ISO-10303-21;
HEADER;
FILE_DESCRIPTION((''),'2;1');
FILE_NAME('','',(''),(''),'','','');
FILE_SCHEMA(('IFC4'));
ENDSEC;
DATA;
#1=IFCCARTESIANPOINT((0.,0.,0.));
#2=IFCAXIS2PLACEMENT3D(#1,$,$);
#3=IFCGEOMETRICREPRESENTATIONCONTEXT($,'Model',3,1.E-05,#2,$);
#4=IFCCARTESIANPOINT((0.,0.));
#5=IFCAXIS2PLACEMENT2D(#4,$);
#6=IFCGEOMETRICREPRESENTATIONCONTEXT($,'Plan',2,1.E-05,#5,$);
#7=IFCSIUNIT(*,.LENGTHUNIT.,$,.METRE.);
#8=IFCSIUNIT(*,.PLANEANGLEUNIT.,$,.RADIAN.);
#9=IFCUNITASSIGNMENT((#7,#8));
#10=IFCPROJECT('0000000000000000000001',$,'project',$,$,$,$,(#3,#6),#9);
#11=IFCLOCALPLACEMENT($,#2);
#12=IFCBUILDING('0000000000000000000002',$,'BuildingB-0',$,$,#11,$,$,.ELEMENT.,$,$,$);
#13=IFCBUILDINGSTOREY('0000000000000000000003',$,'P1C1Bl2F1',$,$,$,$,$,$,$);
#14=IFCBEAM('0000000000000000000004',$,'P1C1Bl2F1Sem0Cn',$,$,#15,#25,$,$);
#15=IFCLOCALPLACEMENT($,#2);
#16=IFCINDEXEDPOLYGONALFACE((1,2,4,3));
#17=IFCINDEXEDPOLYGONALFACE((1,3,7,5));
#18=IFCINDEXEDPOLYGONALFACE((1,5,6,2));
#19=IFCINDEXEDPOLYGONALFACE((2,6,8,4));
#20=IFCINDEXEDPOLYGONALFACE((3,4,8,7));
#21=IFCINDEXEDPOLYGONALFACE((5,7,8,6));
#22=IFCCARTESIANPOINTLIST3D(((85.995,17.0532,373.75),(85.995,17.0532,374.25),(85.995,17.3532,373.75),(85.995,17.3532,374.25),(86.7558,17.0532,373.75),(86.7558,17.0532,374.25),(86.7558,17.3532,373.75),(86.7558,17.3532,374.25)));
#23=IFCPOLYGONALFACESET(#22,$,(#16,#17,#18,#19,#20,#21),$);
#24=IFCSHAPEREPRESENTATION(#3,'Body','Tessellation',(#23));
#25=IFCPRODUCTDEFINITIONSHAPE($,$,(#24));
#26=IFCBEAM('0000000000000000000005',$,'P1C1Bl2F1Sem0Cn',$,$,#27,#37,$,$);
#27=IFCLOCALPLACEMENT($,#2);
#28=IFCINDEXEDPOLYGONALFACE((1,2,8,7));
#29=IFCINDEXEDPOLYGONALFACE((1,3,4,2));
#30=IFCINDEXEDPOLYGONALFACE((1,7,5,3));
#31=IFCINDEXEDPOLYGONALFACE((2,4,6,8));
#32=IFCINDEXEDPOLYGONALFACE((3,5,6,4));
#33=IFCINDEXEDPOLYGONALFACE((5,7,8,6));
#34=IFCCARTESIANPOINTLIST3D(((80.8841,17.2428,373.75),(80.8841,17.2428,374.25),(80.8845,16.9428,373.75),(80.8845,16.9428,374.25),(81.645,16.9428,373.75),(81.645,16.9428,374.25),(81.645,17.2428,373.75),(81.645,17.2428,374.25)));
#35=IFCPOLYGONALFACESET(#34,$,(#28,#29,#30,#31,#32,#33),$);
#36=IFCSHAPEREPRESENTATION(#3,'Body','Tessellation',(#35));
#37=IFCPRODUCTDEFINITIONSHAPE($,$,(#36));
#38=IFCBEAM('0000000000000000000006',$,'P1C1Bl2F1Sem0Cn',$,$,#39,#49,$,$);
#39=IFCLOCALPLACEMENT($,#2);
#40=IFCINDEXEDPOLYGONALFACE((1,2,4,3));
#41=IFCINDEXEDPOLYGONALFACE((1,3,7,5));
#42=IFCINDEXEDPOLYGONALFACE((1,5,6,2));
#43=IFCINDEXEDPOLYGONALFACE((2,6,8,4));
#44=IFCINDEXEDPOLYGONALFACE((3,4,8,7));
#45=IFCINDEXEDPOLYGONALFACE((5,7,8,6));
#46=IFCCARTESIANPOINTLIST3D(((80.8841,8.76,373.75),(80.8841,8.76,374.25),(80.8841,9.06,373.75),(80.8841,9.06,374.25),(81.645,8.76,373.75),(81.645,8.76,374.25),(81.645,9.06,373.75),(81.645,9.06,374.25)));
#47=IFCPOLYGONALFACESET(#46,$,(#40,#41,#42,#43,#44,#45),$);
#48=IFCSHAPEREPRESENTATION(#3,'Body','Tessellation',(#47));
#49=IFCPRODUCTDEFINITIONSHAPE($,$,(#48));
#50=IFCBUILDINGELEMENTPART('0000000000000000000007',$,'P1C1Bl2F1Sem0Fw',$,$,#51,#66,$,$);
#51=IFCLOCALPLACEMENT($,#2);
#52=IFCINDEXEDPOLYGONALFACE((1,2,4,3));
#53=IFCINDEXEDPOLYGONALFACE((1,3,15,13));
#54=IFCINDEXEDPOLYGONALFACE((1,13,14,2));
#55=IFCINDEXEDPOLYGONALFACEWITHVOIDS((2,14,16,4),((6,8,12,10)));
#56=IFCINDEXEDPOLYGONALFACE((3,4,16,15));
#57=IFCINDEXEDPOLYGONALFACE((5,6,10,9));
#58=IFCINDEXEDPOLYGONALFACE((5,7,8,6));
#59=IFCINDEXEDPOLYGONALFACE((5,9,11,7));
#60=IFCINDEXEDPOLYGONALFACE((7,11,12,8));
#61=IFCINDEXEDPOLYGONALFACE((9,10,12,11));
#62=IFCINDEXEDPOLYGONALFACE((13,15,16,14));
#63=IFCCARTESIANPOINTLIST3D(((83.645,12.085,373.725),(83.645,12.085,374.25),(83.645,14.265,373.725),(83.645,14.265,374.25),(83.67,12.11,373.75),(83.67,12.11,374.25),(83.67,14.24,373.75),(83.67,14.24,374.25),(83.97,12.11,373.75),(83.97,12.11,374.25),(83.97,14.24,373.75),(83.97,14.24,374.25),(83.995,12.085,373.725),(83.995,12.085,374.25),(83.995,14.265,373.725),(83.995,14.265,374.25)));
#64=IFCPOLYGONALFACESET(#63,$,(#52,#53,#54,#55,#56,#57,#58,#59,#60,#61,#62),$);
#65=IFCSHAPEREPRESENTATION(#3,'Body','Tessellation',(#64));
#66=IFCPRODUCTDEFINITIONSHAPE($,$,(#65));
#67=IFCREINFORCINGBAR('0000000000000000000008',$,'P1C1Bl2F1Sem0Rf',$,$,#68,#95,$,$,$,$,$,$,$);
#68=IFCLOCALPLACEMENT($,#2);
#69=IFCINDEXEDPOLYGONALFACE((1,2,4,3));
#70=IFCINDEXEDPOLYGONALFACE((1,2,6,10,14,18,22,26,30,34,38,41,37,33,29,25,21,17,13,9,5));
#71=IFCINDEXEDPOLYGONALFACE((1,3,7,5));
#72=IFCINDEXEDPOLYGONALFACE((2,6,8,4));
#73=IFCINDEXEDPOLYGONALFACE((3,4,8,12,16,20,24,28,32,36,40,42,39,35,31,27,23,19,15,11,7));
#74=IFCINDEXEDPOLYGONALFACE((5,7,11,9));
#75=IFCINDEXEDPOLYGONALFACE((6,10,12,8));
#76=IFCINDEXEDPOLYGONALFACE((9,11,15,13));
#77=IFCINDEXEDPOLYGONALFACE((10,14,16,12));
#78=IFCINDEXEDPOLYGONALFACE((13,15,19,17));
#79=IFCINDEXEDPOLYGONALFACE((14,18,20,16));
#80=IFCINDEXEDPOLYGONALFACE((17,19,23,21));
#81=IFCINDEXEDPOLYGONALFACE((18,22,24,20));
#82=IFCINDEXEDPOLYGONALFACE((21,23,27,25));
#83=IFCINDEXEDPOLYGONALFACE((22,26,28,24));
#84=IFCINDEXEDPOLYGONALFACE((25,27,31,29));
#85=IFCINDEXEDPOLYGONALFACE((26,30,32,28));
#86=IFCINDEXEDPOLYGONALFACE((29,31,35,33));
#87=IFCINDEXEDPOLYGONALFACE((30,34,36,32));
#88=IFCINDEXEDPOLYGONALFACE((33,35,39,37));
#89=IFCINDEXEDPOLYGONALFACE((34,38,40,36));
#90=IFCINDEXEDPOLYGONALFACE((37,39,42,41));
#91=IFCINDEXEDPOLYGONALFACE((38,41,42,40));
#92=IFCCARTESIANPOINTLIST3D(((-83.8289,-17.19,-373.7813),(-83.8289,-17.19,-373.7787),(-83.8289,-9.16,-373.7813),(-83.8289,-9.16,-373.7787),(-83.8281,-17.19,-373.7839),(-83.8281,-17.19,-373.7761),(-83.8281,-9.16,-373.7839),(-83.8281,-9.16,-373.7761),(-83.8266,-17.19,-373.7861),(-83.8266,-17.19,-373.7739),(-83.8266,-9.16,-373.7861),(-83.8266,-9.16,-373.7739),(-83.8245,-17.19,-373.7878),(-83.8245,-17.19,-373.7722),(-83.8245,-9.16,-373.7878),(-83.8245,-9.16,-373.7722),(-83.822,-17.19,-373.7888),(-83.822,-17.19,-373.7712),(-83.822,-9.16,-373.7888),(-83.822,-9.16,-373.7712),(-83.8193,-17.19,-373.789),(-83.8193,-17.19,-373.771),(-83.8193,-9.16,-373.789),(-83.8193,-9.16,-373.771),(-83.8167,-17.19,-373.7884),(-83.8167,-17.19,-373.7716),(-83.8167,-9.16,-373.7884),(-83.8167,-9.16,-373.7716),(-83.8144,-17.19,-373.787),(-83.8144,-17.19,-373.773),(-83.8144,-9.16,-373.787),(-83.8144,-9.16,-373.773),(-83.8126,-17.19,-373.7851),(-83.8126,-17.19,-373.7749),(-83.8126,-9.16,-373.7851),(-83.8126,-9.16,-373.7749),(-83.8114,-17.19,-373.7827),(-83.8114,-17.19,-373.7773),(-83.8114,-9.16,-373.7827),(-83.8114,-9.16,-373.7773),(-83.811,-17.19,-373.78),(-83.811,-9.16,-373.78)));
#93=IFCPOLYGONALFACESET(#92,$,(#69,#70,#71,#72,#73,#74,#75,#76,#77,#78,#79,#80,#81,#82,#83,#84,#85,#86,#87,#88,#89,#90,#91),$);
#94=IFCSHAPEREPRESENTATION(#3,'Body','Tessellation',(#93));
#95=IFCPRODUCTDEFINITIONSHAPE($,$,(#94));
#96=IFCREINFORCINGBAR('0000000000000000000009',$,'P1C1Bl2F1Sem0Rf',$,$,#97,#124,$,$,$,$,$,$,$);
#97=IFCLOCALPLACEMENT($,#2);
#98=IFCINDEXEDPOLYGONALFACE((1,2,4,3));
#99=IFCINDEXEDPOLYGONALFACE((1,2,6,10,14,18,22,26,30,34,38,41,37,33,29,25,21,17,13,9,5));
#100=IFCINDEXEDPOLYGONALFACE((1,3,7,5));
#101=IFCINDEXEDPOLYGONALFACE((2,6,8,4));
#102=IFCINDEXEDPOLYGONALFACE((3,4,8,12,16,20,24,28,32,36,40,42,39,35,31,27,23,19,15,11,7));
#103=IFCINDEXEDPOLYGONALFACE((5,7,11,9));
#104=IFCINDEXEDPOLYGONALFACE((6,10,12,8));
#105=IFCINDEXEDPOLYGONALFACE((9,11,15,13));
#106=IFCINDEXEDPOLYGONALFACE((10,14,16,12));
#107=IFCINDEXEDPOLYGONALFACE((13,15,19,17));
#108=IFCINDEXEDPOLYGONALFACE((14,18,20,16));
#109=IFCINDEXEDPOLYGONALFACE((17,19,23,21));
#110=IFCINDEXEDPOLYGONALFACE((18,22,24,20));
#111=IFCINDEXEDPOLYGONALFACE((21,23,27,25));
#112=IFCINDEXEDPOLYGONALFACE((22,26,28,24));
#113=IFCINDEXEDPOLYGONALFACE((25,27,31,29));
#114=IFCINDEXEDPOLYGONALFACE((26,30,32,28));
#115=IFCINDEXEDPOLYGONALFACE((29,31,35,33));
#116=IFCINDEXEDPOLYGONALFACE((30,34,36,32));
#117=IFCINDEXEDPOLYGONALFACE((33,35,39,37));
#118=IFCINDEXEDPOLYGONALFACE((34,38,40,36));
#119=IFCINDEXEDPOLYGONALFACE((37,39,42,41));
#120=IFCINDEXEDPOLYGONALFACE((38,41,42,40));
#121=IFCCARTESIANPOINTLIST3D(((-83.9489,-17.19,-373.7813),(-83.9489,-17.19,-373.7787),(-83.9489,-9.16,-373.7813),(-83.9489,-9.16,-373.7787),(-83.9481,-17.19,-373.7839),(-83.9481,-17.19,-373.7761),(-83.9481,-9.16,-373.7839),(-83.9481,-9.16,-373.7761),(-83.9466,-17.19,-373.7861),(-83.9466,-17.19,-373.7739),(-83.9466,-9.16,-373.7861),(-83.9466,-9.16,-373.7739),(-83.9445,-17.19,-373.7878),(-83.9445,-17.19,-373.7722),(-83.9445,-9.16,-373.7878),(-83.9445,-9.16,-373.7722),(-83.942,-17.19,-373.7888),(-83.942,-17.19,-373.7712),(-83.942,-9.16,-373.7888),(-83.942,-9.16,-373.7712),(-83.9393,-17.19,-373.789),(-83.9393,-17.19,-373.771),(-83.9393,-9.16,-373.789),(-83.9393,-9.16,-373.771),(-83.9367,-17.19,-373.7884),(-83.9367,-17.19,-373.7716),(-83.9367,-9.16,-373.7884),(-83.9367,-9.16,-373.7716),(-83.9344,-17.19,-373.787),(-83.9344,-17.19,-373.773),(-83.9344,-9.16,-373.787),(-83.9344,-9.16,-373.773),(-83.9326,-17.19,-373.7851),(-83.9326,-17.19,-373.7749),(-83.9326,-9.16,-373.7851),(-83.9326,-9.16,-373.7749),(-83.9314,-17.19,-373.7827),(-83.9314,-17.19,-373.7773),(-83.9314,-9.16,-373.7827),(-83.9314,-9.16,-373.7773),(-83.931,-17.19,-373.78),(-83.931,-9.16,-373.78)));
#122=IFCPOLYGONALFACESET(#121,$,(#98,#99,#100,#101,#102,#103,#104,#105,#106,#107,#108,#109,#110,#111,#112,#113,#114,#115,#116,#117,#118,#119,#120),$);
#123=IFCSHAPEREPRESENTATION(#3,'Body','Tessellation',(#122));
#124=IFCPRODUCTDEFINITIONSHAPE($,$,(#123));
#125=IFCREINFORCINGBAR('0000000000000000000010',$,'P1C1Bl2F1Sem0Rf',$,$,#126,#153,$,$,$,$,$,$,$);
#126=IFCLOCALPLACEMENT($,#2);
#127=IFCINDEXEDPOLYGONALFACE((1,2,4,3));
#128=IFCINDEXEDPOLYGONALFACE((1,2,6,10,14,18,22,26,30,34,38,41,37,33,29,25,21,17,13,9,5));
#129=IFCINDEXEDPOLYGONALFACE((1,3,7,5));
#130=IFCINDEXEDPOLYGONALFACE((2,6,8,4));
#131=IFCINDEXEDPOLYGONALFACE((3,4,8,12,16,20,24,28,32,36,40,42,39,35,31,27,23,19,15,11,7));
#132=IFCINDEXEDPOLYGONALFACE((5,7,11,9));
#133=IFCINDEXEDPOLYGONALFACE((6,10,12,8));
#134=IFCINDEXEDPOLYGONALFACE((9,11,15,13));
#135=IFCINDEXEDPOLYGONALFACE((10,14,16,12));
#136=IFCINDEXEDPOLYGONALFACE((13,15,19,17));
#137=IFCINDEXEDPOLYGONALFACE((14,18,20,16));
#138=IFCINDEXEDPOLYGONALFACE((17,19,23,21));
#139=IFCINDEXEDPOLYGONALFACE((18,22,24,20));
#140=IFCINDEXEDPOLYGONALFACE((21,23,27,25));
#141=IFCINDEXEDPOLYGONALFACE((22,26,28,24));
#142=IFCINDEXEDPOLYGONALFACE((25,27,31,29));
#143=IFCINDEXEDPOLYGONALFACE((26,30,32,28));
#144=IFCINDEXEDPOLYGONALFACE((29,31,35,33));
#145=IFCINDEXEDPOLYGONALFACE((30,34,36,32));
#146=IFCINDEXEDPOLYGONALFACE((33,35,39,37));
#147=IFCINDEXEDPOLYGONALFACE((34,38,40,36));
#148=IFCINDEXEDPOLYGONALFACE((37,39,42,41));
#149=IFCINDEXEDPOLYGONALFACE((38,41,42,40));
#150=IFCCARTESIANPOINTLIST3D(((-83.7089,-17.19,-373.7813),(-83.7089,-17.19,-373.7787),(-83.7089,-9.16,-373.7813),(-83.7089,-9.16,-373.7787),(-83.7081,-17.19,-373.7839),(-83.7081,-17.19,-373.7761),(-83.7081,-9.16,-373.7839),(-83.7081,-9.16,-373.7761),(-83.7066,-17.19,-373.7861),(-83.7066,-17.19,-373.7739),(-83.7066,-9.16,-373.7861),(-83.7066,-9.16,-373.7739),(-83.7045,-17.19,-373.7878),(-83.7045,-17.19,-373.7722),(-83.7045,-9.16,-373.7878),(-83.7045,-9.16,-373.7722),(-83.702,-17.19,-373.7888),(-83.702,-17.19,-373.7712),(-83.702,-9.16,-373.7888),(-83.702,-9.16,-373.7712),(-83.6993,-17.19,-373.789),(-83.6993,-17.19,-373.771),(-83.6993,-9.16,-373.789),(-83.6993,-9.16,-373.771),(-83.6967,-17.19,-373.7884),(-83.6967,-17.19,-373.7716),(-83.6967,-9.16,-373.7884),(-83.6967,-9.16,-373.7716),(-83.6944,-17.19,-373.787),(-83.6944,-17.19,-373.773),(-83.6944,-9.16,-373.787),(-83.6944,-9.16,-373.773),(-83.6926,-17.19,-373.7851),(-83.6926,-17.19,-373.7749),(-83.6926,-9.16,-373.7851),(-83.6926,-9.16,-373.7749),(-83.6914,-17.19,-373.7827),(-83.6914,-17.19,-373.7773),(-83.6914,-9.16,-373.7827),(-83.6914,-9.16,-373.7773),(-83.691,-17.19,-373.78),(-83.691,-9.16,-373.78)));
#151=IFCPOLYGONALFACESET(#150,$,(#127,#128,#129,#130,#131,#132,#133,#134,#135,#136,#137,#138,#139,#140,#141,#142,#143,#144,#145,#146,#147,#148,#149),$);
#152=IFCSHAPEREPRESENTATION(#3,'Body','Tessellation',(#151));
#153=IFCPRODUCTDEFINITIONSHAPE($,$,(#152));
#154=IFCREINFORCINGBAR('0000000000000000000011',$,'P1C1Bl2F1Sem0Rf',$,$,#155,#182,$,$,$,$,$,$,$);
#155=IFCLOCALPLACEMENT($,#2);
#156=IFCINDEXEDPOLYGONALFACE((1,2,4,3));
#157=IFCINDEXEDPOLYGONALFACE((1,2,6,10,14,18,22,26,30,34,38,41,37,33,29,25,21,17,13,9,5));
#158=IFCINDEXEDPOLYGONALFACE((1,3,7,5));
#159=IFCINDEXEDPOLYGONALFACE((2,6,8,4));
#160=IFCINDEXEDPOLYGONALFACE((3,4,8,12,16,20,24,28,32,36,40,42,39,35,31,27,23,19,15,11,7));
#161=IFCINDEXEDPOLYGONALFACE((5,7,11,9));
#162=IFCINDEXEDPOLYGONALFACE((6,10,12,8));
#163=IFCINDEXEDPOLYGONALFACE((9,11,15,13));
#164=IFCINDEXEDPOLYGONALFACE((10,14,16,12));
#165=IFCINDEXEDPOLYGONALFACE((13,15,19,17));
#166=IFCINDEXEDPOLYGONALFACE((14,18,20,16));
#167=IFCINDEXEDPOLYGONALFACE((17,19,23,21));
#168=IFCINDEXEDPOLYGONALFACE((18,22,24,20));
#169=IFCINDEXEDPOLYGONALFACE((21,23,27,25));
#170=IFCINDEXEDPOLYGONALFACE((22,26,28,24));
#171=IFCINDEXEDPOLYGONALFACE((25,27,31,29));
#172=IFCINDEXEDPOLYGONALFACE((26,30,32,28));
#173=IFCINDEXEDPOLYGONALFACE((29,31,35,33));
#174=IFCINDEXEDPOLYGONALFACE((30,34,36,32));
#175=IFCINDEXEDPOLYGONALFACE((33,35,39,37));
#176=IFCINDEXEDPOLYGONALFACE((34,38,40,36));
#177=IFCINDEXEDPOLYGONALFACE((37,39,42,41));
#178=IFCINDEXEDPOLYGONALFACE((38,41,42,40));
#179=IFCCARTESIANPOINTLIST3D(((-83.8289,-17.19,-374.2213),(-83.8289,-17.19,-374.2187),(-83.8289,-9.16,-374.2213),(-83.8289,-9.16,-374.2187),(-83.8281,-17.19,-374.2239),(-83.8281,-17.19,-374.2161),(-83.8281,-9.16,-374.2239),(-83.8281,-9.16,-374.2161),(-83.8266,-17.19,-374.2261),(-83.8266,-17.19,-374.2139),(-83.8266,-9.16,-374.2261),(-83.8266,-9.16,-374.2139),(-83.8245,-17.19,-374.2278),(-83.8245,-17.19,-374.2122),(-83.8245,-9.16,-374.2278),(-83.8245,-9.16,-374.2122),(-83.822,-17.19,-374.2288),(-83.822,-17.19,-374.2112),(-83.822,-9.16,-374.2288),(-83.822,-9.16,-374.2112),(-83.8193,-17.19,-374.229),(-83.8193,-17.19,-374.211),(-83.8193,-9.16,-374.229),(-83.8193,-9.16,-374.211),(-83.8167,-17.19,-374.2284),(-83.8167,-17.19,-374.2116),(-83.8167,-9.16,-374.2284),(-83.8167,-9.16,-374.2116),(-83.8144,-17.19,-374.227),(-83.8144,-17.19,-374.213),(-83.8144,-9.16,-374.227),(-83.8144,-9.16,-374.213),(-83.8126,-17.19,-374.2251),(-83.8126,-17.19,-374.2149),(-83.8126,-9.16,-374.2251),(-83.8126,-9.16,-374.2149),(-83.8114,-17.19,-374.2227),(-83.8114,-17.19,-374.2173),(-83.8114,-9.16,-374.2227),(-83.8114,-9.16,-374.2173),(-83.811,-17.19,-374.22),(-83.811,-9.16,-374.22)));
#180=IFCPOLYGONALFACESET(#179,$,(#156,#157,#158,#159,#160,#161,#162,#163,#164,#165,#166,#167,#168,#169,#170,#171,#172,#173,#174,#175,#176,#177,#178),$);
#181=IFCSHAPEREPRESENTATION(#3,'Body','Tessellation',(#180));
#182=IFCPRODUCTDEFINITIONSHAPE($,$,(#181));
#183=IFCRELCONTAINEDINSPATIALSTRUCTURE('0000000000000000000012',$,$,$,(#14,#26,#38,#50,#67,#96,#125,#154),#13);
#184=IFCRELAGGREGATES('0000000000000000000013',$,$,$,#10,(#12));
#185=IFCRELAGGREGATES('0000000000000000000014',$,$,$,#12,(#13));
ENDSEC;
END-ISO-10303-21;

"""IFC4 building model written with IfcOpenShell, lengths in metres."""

from ifc_helpers import new_model, entity, si_unit, origin, origin_2d, place, context, project, spatial, polyline, outline, extrude, element, save


model = new_model("IFC4")

# Units and contexts
model_context = context("Model", 3, precision=1e-05, world=origin())
plan_context = context("Plan", 2, precision=1e-05, world=origin_2d())
ifc_project = project(units=[si_unit("LENGTHUNIT", "METRE"), si_unit("PLANEANGLEUNIT", "RADIAN")], contexts=[model_context, plan_context])

# Building, storey
building_placement = place(None, origin())
building = spatial("IfcBuilding", under=ifc_project, at=building_placement, Name="BuildingB-0", CompositionType="ELEMENT")
storey = spatial("IfcBuildingStorey", under=building, Name="P1C1Bl2F1")

# Beams
element("IfcBeam", 1, inside=storey, Name="P1C1Bl2F1Sem0Cn", context=model_context, shape_type="SweptSolid", body=[
    extrude(outline(polyline([(86.7558, 17.0532, 373.75), (86.7558, 17.3532, 373.75), (85.995, 17.3532, 373.75), (85.995, 17.0532, 373.75), (86.7558, 17.0532, 373.75)])), None, (0.0, 0.0, 1.0), 0.5),
])
element("IfcBeam", 2, inside=storey, Name="P1C1Bl2F1Sem0Cn", context=model_context, shape_type="SweptSolid", body=[
    extrude(outline(polyline([(81.645, 16.9428, 373.75), (80.8845, 16.9428, 373.75), (80.8841, 17.2428, 373.75), (81.645, 17.2428, 373.75), (81.645, 16.9428, 373.75)])), None, (0.0, 0.0, 1.0), 0.5),
])
element("IfcBeam", 3, inside=storey, Name="P1C1Bl2F1Sem0Cn", context=model_context, shape_type="SweptSolid", body=[
    extrude(outline(polyline([(81.645, 8.76, 373.75), (80.8841, 8.76, 373.75), (80.8841, 9.06, 373.75), (81.645, 9.06, 373.75), (81.645, 8.76, 373.75)])), None, (0.0, 0.0, 1.0), 0.5),
])

# Building element part, opening
building_element_part_1 = element("IfcBuildingElementPart", 4, inside=storey, Name="P1C1Bl2F1Sem0Fw", context=model_context, shape_type="SweptSolid", body=[
    extrude(outline(polyline([(83.995, 12.085, 373.725), (83.645, 12.085, 373.725), (83.645, 14.265, 373.725), (83.995, 14.265, 373.725), (83.995, 12.085, 373.725)])), None, (0.0, 0.0, 1.0), 0.525),
])
element("IfcOpeningElement", 5, inside=storey, cuts=building_element_part_1, context=model_context, shape_type="SweptSolid", body=[
    extrude(outline(polyline([(83.97, 12.11, 373.75), (83.67, 12.11, 373.75), (83.67, 14.24, 373.75), (83.97, 14.24, 373.75), (83.97, 12.11, 373.75)])), None, (0.0, 0.0, 1.0), 0.5),
])

# Reinforcing bars
element("IfcReinforcingBar", 6, inside=storey, Name="P1C1Bl2F1Sem0Rf", context=model_context, shape_type="SweptSolid", body=[
    entity("IfcSurfaceCurveSweptAreaSolid", entity("IfcCircleProfileDef", "AREA", None, None, 0.009), None, entity("IfcPolyline", [entity("IfcCartesianPoint", [83.82, 9.16, 373.78]), entity("IfcCartesianPoint", [83.82, 17.19, 373.78])]), None, None, entity("IfcPlane", entity("IfcAxis2Placement3D", entity("IfcCartesianPoint", [83.82, 9.16, 373.78]), entity("IfcDirection", [0.0, 0.0, 1.0]), entity("IfcDirection", [1.0, 0.0, 0.0])))),
])
element("IfcReinforcingBar", 7, inside=storey, Name="P1C1Bl2F1Sem0Rf", context=model_context, shape_type="SweptSolid", body=[
    entity("IfcSurfaceCurveSweptAreaSolid", entity("IfcCircleProfileDef", "AREA", None, None, 0.009), None, entity("IfcPolyline", [entity("IfcCartesianPoint", [83.94, 9.16, 373.78]), entity("IfcCartesianPoint", [83.94, 17.19, 373.78])]), None, None, entity("IfcPlane", entity("IfcAxis2Placement3D", entity("IfcCartesianPoint", [83.94, 9.16, 373.78]), entity("IfcDirection", [0.0, 0.0, 1.0]), entity("IfcDirection", [1.0, 0.0, 0.0])))),
])
element("IfcReinforcingBar", 8, inside=storey, Name="P1C1Bl2F1Sem0Rf", context=model_context, shape_type="SweptSolid", body=[
    entity("IfcSurfaceCurveSweptAreaSolid", entity("IfcCircleProfileDef", "AREA", None, None, 0.009), None, entity("IfcPolyline", [entity("IfcCartesianPoint", [83.7, 9.16, 373.78]), entity("IfcCartesianPoint", [83.7, 17.19, 373.78])]), None, None, entity("IfcPlane", entity("IfcAxis2Placement3D", entity("IfcCartesianPoint", [83.7, 9.16, 373.78]), entity("IfcDirection", [0.0, 0.0, 1.0]), entity("IfcDirection", [1.0, 0.0, 0.0])))),
])
element("IfcReinforcingBar", 9, inside=storey, Name="P1C1Bl2F1Sem0Rf", context=model_context, shape_type="SweptSolid", body=[
    entity("IfcSurfaceCurveSweptAreaSolid", entity("IfcCircleProfileDef", "AREA", None, None, 0.009), None, entity("IfcPolyline", [entity("IfcCartesianPoint", [83.82, 9.16, 374.22]), entity("IfcCartesianPoint", [83.82, 17.19, 374.22])]), None, None, entity("IfcPlane", entity("IfcAxis2Placement3D", entity("IfcCartesianPoint", [83.82, 9.16, 374.22]), entity("IfcDirection", [0.0, 0.0, 1.0]), entity("IfcDirection", [1.0, 0.0, 0.0])))),
])

save(model, "model.ifc")
